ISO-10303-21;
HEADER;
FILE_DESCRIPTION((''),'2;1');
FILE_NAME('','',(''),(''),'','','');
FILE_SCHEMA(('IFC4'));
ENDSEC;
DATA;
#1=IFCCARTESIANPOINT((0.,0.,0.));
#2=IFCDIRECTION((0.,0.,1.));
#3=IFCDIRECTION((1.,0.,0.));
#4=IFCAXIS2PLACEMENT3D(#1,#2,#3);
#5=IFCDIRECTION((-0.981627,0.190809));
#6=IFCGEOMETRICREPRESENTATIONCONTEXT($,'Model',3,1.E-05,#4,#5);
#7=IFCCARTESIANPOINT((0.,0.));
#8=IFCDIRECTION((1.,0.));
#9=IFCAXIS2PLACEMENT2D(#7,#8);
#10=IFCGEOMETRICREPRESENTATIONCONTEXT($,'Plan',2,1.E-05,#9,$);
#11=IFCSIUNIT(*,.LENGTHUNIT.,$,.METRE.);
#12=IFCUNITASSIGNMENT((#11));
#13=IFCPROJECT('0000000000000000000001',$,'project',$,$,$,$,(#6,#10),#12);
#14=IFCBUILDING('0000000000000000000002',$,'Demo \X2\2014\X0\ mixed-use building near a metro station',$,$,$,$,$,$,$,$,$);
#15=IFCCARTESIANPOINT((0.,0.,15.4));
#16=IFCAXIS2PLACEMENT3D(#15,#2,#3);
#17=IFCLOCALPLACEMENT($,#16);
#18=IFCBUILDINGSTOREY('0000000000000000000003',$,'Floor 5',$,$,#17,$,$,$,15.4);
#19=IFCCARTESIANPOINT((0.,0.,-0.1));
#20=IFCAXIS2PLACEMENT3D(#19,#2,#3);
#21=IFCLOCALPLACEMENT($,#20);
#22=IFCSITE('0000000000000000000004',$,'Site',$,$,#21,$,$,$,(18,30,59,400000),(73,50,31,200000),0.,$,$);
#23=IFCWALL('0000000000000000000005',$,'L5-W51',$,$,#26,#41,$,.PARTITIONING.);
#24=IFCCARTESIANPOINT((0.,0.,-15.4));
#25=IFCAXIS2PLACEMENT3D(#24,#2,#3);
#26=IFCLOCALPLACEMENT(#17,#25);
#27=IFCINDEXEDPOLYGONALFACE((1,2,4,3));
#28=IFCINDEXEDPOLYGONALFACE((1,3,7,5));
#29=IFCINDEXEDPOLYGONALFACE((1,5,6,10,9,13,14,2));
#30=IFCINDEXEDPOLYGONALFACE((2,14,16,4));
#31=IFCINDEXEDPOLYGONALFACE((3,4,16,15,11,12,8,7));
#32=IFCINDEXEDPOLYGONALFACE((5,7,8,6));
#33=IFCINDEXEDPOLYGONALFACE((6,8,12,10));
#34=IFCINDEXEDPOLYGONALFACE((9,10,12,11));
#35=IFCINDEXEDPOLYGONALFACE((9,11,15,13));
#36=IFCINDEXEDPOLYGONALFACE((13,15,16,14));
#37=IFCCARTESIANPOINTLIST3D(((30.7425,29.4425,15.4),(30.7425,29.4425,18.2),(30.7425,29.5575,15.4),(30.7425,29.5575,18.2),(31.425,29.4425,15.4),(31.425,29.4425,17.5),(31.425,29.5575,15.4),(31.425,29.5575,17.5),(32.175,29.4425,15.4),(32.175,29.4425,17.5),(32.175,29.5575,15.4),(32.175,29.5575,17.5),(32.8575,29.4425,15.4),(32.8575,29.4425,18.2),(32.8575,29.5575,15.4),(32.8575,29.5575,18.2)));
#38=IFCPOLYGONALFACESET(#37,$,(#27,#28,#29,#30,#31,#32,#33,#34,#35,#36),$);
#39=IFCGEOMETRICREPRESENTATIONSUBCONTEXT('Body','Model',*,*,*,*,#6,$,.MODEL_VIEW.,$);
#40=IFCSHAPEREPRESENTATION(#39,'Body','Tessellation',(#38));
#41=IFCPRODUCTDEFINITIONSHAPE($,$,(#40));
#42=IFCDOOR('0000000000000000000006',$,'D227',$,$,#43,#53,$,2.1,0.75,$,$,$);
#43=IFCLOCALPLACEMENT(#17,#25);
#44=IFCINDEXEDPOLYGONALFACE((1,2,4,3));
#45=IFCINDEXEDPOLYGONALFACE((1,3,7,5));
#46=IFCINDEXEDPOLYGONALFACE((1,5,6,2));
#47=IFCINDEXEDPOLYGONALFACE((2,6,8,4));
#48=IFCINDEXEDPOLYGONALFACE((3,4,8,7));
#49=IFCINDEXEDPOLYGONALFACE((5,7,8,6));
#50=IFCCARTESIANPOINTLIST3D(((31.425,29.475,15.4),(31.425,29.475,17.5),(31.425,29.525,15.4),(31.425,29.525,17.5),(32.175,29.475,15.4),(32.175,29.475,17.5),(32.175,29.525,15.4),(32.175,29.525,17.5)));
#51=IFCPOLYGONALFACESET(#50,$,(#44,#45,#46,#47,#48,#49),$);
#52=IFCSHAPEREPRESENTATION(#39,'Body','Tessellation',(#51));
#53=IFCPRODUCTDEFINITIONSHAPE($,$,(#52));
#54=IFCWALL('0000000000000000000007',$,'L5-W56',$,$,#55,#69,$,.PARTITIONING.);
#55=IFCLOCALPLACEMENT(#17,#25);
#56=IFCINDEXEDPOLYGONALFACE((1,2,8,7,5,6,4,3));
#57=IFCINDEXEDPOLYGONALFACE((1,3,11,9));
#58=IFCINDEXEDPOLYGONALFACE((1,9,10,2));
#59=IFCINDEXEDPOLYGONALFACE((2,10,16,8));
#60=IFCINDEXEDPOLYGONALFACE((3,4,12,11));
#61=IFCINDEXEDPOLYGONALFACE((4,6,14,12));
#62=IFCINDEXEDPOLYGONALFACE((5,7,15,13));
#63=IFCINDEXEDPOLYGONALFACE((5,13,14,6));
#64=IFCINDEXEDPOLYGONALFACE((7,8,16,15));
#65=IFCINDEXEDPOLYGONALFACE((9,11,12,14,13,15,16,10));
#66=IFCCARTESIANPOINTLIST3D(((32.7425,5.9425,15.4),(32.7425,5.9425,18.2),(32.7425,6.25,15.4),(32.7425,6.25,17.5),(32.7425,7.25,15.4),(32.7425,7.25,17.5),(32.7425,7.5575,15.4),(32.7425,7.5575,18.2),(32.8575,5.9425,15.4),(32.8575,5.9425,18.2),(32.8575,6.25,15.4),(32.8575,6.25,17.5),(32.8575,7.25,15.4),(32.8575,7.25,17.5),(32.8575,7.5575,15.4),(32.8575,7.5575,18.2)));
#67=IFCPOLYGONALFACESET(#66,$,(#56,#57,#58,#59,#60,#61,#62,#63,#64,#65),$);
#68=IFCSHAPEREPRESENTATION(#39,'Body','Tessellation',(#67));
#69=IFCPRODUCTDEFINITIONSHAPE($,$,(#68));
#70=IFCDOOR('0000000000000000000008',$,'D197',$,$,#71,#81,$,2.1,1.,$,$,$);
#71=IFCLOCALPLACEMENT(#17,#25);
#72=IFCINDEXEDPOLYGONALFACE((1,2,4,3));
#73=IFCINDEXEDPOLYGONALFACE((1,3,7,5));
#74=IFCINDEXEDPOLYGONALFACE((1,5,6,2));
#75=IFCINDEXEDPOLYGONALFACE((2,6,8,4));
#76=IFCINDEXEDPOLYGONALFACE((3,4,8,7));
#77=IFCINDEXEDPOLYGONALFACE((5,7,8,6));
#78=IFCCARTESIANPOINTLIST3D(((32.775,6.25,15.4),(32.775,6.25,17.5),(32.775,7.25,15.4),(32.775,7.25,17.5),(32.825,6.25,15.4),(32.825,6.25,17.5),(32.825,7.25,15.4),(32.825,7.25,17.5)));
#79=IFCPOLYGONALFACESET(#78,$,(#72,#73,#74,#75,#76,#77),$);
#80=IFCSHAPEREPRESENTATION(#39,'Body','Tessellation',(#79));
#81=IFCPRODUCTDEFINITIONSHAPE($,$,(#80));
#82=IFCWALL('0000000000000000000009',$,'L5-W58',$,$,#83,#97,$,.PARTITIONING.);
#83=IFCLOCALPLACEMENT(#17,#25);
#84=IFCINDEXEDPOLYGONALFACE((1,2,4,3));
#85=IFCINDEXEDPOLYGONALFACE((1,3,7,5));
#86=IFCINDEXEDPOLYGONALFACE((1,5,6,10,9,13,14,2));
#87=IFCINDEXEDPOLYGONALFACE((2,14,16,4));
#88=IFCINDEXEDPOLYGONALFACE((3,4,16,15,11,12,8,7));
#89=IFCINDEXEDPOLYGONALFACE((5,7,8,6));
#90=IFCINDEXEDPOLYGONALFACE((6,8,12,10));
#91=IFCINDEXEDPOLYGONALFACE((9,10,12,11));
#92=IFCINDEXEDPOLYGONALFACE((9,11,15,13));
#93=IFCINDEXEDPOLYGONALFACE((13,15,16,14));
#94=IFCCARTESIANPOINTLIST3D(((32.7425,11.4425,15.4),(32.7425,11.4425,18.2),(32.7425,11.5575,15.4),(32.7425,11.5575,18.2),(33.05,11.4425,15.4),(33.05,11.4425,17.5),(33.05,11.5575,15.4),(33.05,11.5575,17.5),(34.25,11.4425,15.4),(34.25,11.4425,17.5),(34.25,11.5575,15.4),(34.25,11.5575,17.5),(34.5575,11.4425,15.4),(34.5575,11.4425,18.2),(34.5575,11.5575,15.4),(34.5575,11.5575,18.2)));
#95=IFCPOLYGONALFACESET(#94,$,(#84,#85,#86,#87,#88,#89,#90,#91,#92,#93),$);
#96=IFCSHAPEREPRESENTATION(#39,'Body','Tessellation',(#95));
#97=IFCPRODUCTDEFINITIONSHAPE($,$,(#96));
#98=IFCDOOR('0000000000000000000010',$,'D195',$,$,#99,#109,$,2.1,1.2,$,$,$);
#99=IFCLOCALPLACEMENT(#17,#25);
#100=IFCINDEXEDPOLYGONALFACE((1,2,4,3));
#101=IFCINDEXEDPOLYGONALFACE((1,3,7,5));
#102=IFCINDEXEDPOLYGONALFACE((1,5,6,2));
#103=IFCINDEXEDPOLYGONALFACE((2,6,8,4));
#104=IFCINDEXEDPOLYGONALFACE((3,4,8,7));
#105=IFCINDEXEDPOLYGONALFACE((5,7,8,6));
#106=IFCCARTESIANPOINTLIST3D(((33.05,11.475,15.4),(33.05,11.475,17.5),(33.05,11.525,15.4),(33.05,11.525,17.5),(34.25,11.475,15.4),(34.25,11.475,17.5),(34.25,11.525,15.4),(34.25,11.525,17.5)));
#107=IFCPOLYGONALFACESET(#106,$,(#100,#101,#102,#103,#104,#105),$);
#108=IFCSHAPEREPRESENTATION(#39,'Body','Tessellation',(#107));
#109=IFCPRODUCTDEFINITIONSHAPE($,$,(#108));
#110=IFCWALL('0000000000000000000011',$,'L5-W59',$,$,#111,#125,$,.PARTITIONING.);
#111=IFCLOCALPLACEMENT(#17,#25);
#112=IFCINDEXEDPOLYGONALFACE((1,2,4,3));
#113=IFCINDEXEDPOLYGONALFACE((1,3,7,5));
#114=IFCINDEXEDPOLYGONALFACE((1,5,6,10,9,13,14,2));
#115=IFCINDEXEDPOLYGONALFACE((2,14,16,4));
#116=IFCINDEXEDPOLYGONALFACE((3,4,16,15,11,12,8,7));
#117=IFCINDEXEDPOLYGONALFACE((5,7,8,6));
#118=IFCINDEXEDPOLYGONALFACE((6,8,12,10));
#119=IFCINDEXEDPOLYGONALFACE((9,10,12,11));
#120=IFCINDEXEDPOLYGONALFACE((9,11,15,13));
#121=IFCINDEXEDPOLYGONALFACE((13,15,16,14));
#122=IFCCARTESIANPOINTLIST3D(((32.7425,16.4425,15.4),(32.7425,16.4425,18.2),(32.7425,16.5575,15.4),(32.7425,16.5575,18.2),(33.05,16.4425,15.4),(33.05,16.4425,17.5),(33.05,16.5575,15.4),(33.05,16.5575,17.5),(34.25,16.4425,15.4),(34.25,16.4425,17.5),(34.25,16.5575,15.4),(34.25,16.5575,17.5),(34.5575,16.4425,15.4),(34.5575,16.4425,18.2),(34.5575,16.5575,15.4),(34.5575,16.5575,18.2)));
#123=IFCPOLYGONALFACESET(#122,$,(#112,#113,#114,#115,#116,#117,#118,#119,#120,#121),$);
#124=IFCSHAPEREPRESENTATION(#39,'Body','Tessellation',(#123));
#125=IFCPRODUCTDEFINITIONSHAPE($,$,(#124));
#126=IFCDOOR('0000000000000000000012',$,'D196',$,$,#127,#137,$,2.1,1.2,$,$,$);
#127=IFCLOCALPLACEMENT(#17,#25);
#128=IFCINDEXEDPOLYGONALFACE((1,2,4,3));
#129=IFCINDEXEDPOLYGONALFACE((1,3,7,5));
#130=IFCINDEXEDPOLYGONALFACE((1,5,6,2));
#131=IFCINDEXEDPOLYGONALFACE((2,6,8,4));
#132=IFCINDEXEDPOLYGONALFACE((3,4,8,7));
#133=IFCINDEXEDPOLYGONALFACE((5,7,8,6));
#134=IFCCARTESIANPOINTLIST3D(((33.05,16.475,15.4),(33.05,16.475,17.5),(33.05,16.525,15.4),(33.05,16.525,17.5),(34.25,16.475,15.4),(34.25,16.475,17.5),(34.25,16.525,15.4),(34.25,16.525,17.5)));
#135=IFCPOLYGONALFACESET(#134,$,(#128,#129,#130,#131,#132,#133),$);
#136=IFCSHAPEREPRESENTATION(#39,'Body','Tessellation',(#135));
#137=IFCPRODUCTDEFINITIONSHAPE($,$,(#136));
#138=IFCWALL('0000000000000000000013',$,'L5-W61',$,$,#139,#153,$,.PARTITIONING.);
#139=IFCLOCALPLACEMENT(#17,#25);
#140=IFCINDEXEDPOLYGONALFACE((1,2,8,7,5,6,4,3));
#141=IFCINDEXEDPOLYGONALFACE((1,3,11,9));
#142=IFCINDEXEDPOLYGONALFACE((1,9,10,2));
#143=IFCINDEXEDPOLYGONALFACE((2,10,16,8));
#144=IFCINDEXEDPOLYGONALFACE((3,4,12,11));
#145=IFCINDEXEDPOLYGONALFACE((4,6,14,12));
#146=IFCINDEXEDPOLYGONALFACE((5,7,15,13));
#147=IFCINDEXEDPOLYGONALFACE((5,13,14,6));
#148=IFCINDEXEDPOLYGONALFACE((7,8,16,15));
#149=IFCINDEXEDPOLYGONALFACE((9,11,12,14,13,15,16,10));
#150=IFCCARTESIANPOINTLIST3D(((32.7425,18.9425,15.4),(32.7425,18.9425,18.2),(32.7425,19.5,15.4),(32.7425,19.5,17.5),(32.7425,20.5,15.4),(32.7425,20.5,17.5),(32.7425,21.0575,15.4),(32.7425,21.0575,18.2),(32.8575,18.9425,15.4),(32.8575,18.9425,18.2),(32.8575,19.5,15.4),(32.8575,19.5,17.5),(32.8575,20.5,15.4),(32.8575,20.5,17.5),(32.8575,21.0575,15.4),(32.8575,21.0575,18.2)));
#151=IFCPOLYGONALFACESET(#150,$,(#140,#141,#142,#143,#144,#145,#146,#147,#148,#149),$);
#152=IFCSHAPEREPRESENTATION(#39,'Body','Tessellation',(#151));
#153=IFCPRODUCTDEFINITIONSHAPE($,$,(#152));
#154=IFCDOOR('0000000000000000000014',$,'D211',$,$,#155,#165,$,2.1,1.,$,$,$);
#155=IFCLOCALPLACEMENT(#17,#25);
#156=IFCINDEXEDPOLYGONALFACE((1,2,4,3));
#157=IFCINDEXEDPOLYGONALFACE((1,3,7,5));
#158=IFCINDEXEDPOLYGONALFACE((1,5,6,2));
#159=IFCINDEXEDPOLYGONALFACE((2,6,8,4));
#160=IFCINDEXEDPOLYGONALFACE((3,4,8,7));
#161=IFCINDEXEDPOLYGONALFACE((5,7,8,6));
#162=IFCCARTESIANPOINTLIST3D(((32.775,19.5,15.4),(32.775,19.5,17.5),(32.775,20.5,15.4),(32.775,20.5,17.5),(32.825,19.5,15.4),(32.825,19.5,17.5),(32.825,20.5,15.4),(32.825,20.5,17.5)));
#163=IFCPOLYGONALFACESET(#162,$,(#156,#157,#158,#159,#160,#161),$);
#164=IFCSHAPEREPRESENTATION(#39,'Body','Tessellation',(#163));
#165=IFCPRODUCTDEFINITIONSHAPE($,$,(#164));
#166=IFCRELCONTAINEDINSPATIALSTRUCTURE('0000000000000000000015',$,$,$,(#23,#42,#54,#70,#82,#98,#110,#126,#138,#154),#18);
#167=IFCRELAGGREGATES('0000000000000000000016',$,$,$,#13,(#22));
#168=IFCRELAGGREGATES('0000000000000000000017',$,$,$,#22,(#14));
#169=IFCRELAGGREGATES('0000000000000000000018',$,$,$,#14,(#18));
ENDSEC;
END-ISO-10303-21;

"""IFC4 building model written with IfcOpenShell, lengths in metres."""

from ifc_helpers import new_model, si_unit, direction, frame, origin_with_axes, origin_2d_with_axis, place, context, subcontext, project, spatial, line, indexed_curve, outline, extrude, element, fill, save


model = new_model("IFC4")

# Units and contexts
model_context = context("Model", 3, precision=1e-05, world=origin_with_axes(), true_north=direction((-0.981627, 0.190809)))
plan_context = context("Plan", 2, precision=1e-05, world=origin_2d_with_axis())
body_context = subcontext(model_context, "Body", "Model", "MODEL_VIEW")
ifc_project = project(units=[si_unit("LENGTHUNIT", "METRE")], contexts=[model_context, plan_context])

# Site, building, storey
site_placement = place(None, frame((0.0, 0.0, -0.1), z_axis=(0.0, 0.0, 1.0), x_axis=(1.0, 0.0, 0.0)))
site = spatial("IfcSite", under=ifc_project, at=site_placement, Name="Site", RefLatitude=(18, 30, 59, 400000), RefLongitude=(73, 50, 31, 200000), RefElevation=0.0)
building = spatial("IfcBuilding", under=site, Name="Demo — mixed-use building near a metro station")
storey_placement = place(None, frame((0.0, 0.0, 15.4), z_axis=(0.0, 0.0, 1.0), x_axis=(1.0, 0.0, 0.0)))
storey = spatial("IfcBuildingStorey", under=building, at=storey_placement, Name="Floor 5", Elevation=15.4)

# Wall, opening, door
wall_1_placement = place(storey_placement, frame((0.0, 0.0, -15.4), z_axis=(0.0, 0.0, 1.0), x_axis=(1.0, 0.0, 0.0)))
wall_1 = element("IfcWall", 1, at=wall_1_placement, inside=storey, Name="L5-W51", PredefinedType="PARTITIONING", context=body_context, shape_type="SweptSolid", body=[
    extrude(outline(indexed_curve([(32.8575, 29.4425), (30.7425, 29.4425), (30.7425, 29.5575), (32.8575, 29.5575)], segments=[line(1, 2, 3, 4, 1)])), frame((0.0, 0.0, 15.4), z_axis=(0.0, 0.0, 1.0), x_axis=(1.0, 0.0, 0.0)), (0.0, 0.0, 1.0), 2.8),
])
opening_1_placement = place(wall_1_placement, origin_with_axes())
opening_1 = element("IfcOpeningElement", 2, at=opening_1_placement, cuts=wall_1, context=body_context, shape_type="SweptSolid", body=[
    extrude(outline(indexed_curve([(32.175, 29.3925), (31.425, 29.3925), (31.425, 29.6075), (32.175, 29.6075)], segments=[line(1, 2, 3, 4, 1)])), frame((0.0, 0.0, 15.4), z_axis=(0.0, 0.0, 1.0), x_axis=(1.0, 0.0, 0.0)), (0.0, 0.0, 1.0), 2.1),
])
door_1_placement = place(storey_placement, frame((0.0, 0.0, -15.4), z_axis=(0.0, 0.0, 1.0), x_axis=(1.0, 0.0, 0.0)))
door_1 = element("IfcDoor", 3, at=door_1_placement, inside=storey, Name="D227", OverallHeight=2.1, OverallWidth=0.75, context=body_context, shape_type="SweptSolid", body=[
    extrude(outline(indexed_curve([(32.175, 29.475), (31.425, 29.475), (31.425, 29.525), (32.175, 29.525)], segments=[line(1, 2, 3, 4, 1)])), frame((0.0, 0.0, 15.4), z_axis=(0.0, 0.0, 1.0), x_axis=(1.0, 0.0, 0.0)), (0.0, 0.0, 1.0), 2.1),
])
fill(opening_1, door_1)

# Wall, opening, door
wall_2_placement = place(storey_placement, frame((0.0, 0.0, -15.4), z_axis=(0.0, 0.0, 1.0), x_axis=(1.0, 0.0, 0.0)))
wall_2 = element("IfcWall", 4, at=wall_2_placement, inside=storey, Name="L5-W56", PredefinedType="PARTITIONING", context=body_context, shape_type="SweptSolid", body=[
    extrude(outline(indexed_curve([(32.8575, 7.5575), (32.8575, 5.9425), (32.7425, 5.9425), (32.7425, 7.5575)], segments=[line(1, 2, 3, 4, 1)])), frame((0.0, 0.0, 15.4), z_axis=(0.0, 0.0, 1.0), x_axis=(1.0, 0.0, 0.0)), (0.0, 0.0, 1.0), 2.8),
])
opening_2_placement = place(wall_2_placement, origin_with_axes())
opening_2 = element("IfcOpeningElement", 5, at=opening_2_placement, cuts=wall_2, context=body_context, shape_type="SweptSolid", body=[
    extrude(outline(indexed_curve([(32.9075, 7.25), (32.9075, 6.25), (32.6925, 6.25), (32.6925, 7.25)], segments=[line(1, 2, 3, 4, 1)])), frame((0.0, 0.0, 15.4), z_axis=(0.0, 0.0, 1.0), x_axis=(1.0, 0.0, 0.0)), (0.0, 0.0, 1.0), 2.1),
])
door_2_placement = place(storey_placement, frame((0.0, 0.0, -15.4), z_axis=(0.0, 0.0, 1.0), x_axis=(1.0, 0.0, 0.0)))
door_2 = element("IfcDoor", 6, at=door_2_placement, inside=storey, Name="D197", OverallHeight=2.1, OverallWidth=1.0, context=body_context, shape_type="SweptSolid", body=[
    extrude(outline(indexed_curve([(32.825, 7.25), (32.825, 6.25), (32.775, 6.25), (32.775, 7.25)], segments=[line(1, 2, 3, 4, 1)])), frame((0.0, 0.0, 15.4), z_axis=(0.0, 0.0, 1.0), x_axis=(1.0, 0.0, 0.0)), (0.0, 0.0, 1.0), 2.1),
])
fill(opening_2, door_2)

# Walls, openings, doors
wall_3_placement = place(storey_placement, frame((0.0, 0.0, -15.4), z_axis=(0.0, 0.0, 1.0), x_axis=(1.0, 0.0, 0.0)))
wall_3 = element("IfcWall", 7, at=wall_3_placement, inside=storey, Name="L5-W58", PredefinedType="PARTITIONING", context=body_context, shape_type="SweptSolid", body=[
    extrude(outline(indexed_curve([(34.5575, 11.4425), (32.7425, 11.4425), (32.7425, 11.5575), (34.5575, 11.5575)], segments=[line(1, 2, 3, 4, 1)])), frame((0.0, 0.0, 15.4), z_axis=(0.0, 0.0, 1.0), x_axis=(1.0, 0.0, 0.0)), (0.0, 0.0, 1.0), 2.8),
])
opening_3_placement = place(wall_3_placement, origin_with_axes())
opening_3 = element("IfcOpeningElement", 8, at=opening_3_placement, cuts=wall_3, context=body_context, shape_type="SweptSolid", body=[
    extrude(outline(indexed_curve([(34.25, 11.3925), (33.05, 11.3925), (33.05, 11.6075), (34.25, 11.6075)], segments=[line(1, 2, 3, 4, 1)])), frame((0.0, 0.0, 15.4), z_axis=(0.0, 0.0, 1.0), x_axis=(1.0, 0.0, 0.0)), (0.0, 0.0, 1.0), 2.1),
])
door_3_placement = place(storey_placement, frame((0.0, 0.0, -15.4), z_axis=(0.0, 0.0, 1.0), x_axis=(1.0, 0.0, 0.0)))
door_3 = element("IfcDoor", 9, at=door_3_placement, inside=storey, Name="D195", OverallHeight=2.1, OverallWidth=1.2, context=body_context, shape_type="SweptSolid", body=[
    extrude(outline(indexed_curve([(34.25, 11.475), (33.05, 11.475), (33.05, 11.525), (34.25, 11.525)], segments=[line(1, 2, 3, 4, 1)])), frame((0.0, 0.0, 15.4), z_axis=(0.0, 0.0, 1.0), x_axis=(1.0, 0.0, 0.0)), (0.0, 0.0, 1.0), 2.1),
])
fill(opening_3, door_3)
wall_4_placement = place(storey_placement, frame((0.0, 0.0, -15.4), z_axis=(0.0, 0.0, 1.0), x_axis=(1.0, 0.0, 0.0)))
wall_4 = element("IfcWall", 10, at=wall_4_placement, inside=storey, Name="L5-W59", PredefinedType="PARTITIONING", context=body_context, shape_type="SweptSolid", body=[
    extrude(outline(indexed_curve([(34.5575, 16.4425), (32.7425, 16.4425), (32.7425, 16.5575), (34.5575, 16.5575)], segments=[line(1, 2, 3, 4, 1)])), frame((0.0, 0.0, 15.4), z_axis=(0.0, 0.0, 1.0), x_axis=(1.0, 0.0, 0.0)), (0.0, 0.0, 1.0), 2.8),
])
opening_4_placement = place(wall_4_placement, origin_with_axes())
opening_4 = element("IfcOpeningElement", 11, at=opening_4_placement, cuts=wall_4, context=body_context, shape_type="SweptSolid", body=[
    extrude(outline(indexed_curve([(34.25, 16.3925), (33.05, 16.3925), (33.05, 16.6075), (34.25, 16.6075)], segments=[line(1, 2, 3, 4, 1)])), frame((0.0, 0.0, 15.4), z_axis=(0.0, 0.0, 1.0), x_axis=(1.0, 0.0, 0.0)), (0.0, 0.0, 1.0), 2.1),
])
door_4_placement = place(storey_placement, frame((0.0, 0.0, -15.4), z_axis=(0.0, 0.0, 1.0), x_axis=(1.0, 0.0, 0.0)))
door_4 = element("IfcDoor", 12, at=door_4_placement, inside=storey, Name="D196", OverallHeight=2.1, OverallWidth=1.2, context=body_context, shape_type="SweptSolid", body=[
    extrude(outline(indexed_curve([(34.25, 16.475), (33.05, 16.475), (33.05, 16.525), (34.25, 16.525)], segments=[line(1, 2, 3, 4, 1)])), frame((0.0, 0.0, 15.4), z_axis=(0.0, 0.0, 1.0), x_axis=(1.0, 0.0, 0.0)), (0.0, 0.0, 1.0), 2.1),
])
fill(opening_4, door_4)

# Wall, opening, door
wall_5_placement = place(storey_placement, frame((0.0, 0.0, -15.4), z_axis=(0.0, 0.0, 1.0), x_axis=(1.0, 0.0, 0.0)))
wall_5 = element("IfcWall", 13, at=wall_5_placement, inside=storey, Name="L5-W61", PredefinedType="PARTITIONING", context=body_context, shape_type="SweptSolid", body=[
    extrude(outline(indexed_curve([(32.8575, 21.0575), (32.8575, 18.9425), (32.7425, 18.9425), (32.7425, 21.0575)], segments=[line(1, 2, 3, 4, 1)])), frame((0.0, 0.0, 15.4), z_axis=(0.0, 0.0, 1.0), x_axis=(1.0, 0.0, 0.0)), (0.0, 0.0, 1.0), 2.8),
])
opening_5_placement = place(wall_5_placement, origin_with_axes())
opening_5 = element("IfcOpeningElement", 14, at=opening_5_placement, cuts=wall_5, context=body_context, shape_type="SweptSolid", body=[
    extrude(outline(indexed_curve([(32.9075, 20.5), (32.9075, 19.5), (32.6925, 19.5), (32.6925, 20.5)], segments=[line(1, 2, 3, 4, 1)])), frame((0.0, 0.0, 15.4), z_axis=(0.0, 0.0, 1.0), x_axis=(1.0, 0.0, 0.0)), (0.0, 0.0, 1.0), 2.1),
])
door_5_placement = place(storey_placement, frame((0.0, 0.0, -15.4), z_axis=(0.0, 0.0, 1.0), x_axis=(1.0, 0.0, 0.0)))
door_5 = element("IfcDoor", 15, at=door_5_placement, inside=storey, Name="D211", OverallHeight=2.1, OverallWidth=1.0, context=body_context, shape_type="SweptSolid", body=[
    extrude(outline(indexed_curve([(32.825, 20.5), (32.825, 19.5), (32.775, 19.5), (32.775, 20.5)], segments=[line(1, 2, 3, 4, 1)])), frame((0.0, 0.0, 15.4), z_axis=(0.0, 0.0, 1.0), x_axis=(1.0, 0.0, 0.0)), (0.0, 0.0, 1.0), 2.1),
])
fill(opening_5, door_5)

save(model, "model.ifc")
